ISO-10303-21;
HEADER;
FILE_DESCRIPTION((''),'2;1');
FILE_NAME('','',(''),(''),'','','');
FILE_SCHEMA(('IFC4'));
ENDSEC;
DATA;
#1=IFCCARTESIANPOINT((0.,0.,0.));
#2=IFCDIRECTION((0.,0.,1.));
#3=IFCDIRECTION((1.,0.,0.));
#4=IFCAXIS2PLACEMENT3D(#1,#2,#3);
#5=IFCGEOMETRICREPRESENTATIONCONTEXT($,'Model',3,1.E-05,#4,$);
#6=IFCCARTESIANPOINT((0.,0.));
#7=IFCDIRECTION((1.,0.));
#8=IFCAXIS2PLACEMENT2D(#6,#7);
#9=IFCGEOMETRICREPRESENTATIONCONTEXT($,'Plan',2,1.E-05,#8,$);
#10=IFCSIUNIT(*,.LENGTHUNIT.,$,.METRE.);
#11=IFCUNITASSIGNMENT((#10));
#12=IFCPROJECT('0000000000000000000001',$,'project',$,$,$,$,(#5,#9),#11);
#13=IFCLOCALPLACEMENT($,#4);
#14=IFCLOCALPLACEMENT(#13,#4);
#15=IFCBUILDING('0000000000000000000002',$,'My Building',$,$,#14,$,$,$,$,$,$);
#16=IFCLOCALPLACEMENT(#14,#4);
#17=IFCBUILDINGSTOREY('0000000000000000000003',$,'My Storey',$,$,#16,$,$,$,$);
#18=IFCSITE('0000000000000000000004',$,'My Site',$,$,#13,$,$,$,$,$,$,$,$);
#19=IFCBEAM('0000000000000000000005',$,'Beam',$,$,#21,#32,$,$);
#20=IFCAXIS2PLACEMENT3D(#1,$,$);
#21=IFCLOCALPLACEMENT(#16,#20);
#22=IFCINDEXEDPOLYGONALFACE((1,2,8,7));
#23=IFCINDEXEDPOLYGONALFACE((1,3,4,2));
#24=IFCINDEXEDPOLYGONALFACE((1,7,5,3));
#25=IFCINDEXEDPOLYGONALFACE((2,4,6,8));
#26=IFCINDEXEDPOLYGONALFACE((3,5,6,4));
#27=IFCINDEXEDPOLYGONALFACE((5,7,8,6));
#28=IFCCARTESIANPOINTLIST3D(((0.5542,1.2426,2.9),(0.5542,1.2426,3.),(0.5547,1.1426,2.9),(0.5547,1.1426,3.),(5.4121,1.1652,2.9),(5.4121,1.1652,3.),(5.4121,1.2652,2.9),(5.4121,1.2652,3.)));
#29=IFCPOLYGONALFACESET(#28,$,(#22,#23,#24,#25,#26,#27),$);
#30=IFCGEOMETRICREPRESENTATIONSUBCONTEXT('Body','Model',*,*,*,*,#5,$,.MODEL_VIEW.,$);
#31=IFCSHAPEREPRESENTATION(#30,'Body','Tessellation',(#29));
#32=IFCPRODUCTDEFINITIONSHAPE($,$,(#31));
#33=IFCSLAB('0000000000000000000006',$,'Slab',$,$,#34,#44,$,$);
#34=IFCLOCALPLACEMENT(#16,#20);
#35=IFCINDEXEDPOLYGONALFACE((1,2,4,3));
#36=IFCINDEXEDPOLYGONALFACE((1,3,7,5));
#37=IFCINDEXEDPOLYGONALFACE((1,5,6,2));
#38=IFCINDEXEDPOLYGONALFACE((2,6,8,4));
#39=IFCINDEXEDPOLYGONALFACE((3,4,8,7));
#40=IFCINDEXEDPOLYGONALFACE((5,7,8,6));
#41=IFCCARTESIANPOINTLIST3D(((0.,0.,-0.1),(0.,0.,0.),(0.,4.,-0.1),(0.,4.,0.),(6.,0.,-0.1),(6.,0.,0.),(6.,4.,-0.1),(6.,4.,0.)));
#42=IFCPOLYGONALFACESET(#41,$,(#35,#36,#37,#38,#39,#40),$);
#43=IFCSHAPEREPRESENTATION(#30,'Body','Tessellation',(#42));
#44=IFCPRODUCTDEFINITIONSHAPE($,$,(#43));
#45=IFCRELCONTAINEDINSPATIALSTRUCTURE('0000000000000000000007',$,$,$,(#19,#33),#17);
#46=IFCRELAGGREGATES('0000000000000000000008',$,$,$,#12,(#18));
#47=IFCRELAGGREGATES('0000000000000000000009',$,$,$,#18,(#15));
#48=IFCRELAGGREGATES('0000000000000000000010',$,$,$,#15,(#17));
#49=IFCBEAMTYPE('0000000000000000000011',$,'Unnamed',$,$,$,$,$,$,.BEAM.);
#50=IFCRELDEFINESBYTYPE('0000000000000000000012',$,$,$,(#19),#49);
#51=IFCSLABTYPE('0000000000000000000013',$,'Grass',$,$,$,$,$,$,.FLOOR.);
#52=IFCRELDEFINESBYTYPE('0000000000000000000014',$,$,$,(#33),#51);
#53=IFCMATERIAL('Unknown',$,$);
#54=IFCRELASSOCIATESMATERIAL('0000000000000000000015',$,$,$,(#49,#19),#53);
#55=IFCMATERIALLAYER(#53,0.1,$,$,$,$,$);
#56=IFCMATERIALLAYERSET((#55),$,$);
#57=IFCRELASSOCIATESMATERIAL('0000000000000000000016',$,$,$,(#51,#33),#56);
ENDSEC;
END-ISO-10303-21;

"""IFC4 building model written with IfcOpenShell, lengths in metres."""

from ifc_helpers import new_model, si_unit, frame, origin_with_axes, origin_2d_with_axis, place, context, subcontext, project, spatial, indexed_curve, rectangle, outline, extrude, clip, halfspace, material, layer, layer_set, layer_usage, material_profile, profile_set, profile_usage, type_object, element, save


model = new_model("IFC4")

# Units and contexts
model_context = context("Model", 3, precision=1e-05, world=origin_with_axes())
plan_context = context("Plan", 2, precision=1e-05, world=origin_2d_with_axis())
body_context = subcontext(model_context, "Body", "Model", "MODEL_VIEW")
ifc_project = project(units=[si_unit("LENGTHUNIT", "METRE")], contexts=[model_context, plan_context])

# Site, building, storey
site_placement = place(None, origin_with_axes())
site = spatial("IfcSite", under=ifc_project, at=site_placement, Name="My Site")
building_placement = place(site_placement, origin_with_axes())
building = spatial("IfcBuilding", under=site, at=building_placement, Name="My Building")
storey_placement = place(building_placement, origin_with_axes())
storey = spatial("IfcBuildingStorey", under=building, at=storey_placement, Name="My Storey")

# Shared definitions
ifc_material = material(Name="Unknown")

# Beam
ifc_material_profile_1 = material_profile(ifc_material, rectangle(XDim=0.1, YDim=0.1))
ifc_profile_set_1 = profile_set([ifc_material_profile_1])
beam_type = type_object("IfcBeamType", Name="Unnamed", PredefinedType="BEAM", material=ifc_profile_set_1)
ifc_profile_usage_1 = profile_usage(ifc_profile_set_1, cardinal=7)
beam_1_placement = place(storey_placement, frame((0.5542, 1.2426, 3.0), z_axis=(0.999989, 0.004651, 0.0), x_axis=(-0.004651, 0.999989, 0.0)))
element("IfcBeam", 1, at=beam_1_placement, inside=storey, type_object=beam_type, material=ifc_profile_usage_1, Name="Beam", context=body_context, shape_type="Clipping", body=[
    clip(extrude(rectangle(XDim=0.1, YDim=0.1), frame((-0.05, -0.05, 0.0), z_axis=(0.0, 0.0, 1.0), x_axis=(1.0, 0.0, 0.0)), (0.0, 0.0, 1.0), 4.9579), halfspace(frame((1.7848, -3.0, 4.8662), z_axis=(-0.004651, 0.0, 0.999989), x_axis=(-0.999989, 0.0, -0.004651)), False)),
])

# Slab
ifc_layer = layer(ifc_material, 0.1)
ifc_layer_set = layer_set([ifc_layer])
ifc_layer_usage = layer_usage(ifc_layer_set, "AXIS3", "POSITIVE", -0.1)
slab_type = type_object("IfcSlabType", Name="Grass", PredefinedType="FLOOR", material=ifc_layer_set)
slab_placement = place(storey_placement, frame((0.0, 4.0, 0.0), z_axis=(0.0, 0.0, 1.0), x_axis=(1.0, 0.0, 0.0)))
element("IfcSlab", 2, at=slab_placement, inside=storey, type_object=slab_type, material=ifc_layer_usage, Name="Slab", context=body_context, shape_type="SweptSolid", body=[
    extrude(outline(indexed_curve([(0.0, 0.0), (6.0, 0.0), (6.0, -4.0), (0.0, -4.0), (0.0, 0.0)])), frame((0.0, 0.0, -0.1), z_axis=(0.0, 0.0, 1.0), x_axis=(1.0, 0.0, 0.0)), (0.0, 0.0, 1.0), 0.1),
])

save(model, "model.ifc")
